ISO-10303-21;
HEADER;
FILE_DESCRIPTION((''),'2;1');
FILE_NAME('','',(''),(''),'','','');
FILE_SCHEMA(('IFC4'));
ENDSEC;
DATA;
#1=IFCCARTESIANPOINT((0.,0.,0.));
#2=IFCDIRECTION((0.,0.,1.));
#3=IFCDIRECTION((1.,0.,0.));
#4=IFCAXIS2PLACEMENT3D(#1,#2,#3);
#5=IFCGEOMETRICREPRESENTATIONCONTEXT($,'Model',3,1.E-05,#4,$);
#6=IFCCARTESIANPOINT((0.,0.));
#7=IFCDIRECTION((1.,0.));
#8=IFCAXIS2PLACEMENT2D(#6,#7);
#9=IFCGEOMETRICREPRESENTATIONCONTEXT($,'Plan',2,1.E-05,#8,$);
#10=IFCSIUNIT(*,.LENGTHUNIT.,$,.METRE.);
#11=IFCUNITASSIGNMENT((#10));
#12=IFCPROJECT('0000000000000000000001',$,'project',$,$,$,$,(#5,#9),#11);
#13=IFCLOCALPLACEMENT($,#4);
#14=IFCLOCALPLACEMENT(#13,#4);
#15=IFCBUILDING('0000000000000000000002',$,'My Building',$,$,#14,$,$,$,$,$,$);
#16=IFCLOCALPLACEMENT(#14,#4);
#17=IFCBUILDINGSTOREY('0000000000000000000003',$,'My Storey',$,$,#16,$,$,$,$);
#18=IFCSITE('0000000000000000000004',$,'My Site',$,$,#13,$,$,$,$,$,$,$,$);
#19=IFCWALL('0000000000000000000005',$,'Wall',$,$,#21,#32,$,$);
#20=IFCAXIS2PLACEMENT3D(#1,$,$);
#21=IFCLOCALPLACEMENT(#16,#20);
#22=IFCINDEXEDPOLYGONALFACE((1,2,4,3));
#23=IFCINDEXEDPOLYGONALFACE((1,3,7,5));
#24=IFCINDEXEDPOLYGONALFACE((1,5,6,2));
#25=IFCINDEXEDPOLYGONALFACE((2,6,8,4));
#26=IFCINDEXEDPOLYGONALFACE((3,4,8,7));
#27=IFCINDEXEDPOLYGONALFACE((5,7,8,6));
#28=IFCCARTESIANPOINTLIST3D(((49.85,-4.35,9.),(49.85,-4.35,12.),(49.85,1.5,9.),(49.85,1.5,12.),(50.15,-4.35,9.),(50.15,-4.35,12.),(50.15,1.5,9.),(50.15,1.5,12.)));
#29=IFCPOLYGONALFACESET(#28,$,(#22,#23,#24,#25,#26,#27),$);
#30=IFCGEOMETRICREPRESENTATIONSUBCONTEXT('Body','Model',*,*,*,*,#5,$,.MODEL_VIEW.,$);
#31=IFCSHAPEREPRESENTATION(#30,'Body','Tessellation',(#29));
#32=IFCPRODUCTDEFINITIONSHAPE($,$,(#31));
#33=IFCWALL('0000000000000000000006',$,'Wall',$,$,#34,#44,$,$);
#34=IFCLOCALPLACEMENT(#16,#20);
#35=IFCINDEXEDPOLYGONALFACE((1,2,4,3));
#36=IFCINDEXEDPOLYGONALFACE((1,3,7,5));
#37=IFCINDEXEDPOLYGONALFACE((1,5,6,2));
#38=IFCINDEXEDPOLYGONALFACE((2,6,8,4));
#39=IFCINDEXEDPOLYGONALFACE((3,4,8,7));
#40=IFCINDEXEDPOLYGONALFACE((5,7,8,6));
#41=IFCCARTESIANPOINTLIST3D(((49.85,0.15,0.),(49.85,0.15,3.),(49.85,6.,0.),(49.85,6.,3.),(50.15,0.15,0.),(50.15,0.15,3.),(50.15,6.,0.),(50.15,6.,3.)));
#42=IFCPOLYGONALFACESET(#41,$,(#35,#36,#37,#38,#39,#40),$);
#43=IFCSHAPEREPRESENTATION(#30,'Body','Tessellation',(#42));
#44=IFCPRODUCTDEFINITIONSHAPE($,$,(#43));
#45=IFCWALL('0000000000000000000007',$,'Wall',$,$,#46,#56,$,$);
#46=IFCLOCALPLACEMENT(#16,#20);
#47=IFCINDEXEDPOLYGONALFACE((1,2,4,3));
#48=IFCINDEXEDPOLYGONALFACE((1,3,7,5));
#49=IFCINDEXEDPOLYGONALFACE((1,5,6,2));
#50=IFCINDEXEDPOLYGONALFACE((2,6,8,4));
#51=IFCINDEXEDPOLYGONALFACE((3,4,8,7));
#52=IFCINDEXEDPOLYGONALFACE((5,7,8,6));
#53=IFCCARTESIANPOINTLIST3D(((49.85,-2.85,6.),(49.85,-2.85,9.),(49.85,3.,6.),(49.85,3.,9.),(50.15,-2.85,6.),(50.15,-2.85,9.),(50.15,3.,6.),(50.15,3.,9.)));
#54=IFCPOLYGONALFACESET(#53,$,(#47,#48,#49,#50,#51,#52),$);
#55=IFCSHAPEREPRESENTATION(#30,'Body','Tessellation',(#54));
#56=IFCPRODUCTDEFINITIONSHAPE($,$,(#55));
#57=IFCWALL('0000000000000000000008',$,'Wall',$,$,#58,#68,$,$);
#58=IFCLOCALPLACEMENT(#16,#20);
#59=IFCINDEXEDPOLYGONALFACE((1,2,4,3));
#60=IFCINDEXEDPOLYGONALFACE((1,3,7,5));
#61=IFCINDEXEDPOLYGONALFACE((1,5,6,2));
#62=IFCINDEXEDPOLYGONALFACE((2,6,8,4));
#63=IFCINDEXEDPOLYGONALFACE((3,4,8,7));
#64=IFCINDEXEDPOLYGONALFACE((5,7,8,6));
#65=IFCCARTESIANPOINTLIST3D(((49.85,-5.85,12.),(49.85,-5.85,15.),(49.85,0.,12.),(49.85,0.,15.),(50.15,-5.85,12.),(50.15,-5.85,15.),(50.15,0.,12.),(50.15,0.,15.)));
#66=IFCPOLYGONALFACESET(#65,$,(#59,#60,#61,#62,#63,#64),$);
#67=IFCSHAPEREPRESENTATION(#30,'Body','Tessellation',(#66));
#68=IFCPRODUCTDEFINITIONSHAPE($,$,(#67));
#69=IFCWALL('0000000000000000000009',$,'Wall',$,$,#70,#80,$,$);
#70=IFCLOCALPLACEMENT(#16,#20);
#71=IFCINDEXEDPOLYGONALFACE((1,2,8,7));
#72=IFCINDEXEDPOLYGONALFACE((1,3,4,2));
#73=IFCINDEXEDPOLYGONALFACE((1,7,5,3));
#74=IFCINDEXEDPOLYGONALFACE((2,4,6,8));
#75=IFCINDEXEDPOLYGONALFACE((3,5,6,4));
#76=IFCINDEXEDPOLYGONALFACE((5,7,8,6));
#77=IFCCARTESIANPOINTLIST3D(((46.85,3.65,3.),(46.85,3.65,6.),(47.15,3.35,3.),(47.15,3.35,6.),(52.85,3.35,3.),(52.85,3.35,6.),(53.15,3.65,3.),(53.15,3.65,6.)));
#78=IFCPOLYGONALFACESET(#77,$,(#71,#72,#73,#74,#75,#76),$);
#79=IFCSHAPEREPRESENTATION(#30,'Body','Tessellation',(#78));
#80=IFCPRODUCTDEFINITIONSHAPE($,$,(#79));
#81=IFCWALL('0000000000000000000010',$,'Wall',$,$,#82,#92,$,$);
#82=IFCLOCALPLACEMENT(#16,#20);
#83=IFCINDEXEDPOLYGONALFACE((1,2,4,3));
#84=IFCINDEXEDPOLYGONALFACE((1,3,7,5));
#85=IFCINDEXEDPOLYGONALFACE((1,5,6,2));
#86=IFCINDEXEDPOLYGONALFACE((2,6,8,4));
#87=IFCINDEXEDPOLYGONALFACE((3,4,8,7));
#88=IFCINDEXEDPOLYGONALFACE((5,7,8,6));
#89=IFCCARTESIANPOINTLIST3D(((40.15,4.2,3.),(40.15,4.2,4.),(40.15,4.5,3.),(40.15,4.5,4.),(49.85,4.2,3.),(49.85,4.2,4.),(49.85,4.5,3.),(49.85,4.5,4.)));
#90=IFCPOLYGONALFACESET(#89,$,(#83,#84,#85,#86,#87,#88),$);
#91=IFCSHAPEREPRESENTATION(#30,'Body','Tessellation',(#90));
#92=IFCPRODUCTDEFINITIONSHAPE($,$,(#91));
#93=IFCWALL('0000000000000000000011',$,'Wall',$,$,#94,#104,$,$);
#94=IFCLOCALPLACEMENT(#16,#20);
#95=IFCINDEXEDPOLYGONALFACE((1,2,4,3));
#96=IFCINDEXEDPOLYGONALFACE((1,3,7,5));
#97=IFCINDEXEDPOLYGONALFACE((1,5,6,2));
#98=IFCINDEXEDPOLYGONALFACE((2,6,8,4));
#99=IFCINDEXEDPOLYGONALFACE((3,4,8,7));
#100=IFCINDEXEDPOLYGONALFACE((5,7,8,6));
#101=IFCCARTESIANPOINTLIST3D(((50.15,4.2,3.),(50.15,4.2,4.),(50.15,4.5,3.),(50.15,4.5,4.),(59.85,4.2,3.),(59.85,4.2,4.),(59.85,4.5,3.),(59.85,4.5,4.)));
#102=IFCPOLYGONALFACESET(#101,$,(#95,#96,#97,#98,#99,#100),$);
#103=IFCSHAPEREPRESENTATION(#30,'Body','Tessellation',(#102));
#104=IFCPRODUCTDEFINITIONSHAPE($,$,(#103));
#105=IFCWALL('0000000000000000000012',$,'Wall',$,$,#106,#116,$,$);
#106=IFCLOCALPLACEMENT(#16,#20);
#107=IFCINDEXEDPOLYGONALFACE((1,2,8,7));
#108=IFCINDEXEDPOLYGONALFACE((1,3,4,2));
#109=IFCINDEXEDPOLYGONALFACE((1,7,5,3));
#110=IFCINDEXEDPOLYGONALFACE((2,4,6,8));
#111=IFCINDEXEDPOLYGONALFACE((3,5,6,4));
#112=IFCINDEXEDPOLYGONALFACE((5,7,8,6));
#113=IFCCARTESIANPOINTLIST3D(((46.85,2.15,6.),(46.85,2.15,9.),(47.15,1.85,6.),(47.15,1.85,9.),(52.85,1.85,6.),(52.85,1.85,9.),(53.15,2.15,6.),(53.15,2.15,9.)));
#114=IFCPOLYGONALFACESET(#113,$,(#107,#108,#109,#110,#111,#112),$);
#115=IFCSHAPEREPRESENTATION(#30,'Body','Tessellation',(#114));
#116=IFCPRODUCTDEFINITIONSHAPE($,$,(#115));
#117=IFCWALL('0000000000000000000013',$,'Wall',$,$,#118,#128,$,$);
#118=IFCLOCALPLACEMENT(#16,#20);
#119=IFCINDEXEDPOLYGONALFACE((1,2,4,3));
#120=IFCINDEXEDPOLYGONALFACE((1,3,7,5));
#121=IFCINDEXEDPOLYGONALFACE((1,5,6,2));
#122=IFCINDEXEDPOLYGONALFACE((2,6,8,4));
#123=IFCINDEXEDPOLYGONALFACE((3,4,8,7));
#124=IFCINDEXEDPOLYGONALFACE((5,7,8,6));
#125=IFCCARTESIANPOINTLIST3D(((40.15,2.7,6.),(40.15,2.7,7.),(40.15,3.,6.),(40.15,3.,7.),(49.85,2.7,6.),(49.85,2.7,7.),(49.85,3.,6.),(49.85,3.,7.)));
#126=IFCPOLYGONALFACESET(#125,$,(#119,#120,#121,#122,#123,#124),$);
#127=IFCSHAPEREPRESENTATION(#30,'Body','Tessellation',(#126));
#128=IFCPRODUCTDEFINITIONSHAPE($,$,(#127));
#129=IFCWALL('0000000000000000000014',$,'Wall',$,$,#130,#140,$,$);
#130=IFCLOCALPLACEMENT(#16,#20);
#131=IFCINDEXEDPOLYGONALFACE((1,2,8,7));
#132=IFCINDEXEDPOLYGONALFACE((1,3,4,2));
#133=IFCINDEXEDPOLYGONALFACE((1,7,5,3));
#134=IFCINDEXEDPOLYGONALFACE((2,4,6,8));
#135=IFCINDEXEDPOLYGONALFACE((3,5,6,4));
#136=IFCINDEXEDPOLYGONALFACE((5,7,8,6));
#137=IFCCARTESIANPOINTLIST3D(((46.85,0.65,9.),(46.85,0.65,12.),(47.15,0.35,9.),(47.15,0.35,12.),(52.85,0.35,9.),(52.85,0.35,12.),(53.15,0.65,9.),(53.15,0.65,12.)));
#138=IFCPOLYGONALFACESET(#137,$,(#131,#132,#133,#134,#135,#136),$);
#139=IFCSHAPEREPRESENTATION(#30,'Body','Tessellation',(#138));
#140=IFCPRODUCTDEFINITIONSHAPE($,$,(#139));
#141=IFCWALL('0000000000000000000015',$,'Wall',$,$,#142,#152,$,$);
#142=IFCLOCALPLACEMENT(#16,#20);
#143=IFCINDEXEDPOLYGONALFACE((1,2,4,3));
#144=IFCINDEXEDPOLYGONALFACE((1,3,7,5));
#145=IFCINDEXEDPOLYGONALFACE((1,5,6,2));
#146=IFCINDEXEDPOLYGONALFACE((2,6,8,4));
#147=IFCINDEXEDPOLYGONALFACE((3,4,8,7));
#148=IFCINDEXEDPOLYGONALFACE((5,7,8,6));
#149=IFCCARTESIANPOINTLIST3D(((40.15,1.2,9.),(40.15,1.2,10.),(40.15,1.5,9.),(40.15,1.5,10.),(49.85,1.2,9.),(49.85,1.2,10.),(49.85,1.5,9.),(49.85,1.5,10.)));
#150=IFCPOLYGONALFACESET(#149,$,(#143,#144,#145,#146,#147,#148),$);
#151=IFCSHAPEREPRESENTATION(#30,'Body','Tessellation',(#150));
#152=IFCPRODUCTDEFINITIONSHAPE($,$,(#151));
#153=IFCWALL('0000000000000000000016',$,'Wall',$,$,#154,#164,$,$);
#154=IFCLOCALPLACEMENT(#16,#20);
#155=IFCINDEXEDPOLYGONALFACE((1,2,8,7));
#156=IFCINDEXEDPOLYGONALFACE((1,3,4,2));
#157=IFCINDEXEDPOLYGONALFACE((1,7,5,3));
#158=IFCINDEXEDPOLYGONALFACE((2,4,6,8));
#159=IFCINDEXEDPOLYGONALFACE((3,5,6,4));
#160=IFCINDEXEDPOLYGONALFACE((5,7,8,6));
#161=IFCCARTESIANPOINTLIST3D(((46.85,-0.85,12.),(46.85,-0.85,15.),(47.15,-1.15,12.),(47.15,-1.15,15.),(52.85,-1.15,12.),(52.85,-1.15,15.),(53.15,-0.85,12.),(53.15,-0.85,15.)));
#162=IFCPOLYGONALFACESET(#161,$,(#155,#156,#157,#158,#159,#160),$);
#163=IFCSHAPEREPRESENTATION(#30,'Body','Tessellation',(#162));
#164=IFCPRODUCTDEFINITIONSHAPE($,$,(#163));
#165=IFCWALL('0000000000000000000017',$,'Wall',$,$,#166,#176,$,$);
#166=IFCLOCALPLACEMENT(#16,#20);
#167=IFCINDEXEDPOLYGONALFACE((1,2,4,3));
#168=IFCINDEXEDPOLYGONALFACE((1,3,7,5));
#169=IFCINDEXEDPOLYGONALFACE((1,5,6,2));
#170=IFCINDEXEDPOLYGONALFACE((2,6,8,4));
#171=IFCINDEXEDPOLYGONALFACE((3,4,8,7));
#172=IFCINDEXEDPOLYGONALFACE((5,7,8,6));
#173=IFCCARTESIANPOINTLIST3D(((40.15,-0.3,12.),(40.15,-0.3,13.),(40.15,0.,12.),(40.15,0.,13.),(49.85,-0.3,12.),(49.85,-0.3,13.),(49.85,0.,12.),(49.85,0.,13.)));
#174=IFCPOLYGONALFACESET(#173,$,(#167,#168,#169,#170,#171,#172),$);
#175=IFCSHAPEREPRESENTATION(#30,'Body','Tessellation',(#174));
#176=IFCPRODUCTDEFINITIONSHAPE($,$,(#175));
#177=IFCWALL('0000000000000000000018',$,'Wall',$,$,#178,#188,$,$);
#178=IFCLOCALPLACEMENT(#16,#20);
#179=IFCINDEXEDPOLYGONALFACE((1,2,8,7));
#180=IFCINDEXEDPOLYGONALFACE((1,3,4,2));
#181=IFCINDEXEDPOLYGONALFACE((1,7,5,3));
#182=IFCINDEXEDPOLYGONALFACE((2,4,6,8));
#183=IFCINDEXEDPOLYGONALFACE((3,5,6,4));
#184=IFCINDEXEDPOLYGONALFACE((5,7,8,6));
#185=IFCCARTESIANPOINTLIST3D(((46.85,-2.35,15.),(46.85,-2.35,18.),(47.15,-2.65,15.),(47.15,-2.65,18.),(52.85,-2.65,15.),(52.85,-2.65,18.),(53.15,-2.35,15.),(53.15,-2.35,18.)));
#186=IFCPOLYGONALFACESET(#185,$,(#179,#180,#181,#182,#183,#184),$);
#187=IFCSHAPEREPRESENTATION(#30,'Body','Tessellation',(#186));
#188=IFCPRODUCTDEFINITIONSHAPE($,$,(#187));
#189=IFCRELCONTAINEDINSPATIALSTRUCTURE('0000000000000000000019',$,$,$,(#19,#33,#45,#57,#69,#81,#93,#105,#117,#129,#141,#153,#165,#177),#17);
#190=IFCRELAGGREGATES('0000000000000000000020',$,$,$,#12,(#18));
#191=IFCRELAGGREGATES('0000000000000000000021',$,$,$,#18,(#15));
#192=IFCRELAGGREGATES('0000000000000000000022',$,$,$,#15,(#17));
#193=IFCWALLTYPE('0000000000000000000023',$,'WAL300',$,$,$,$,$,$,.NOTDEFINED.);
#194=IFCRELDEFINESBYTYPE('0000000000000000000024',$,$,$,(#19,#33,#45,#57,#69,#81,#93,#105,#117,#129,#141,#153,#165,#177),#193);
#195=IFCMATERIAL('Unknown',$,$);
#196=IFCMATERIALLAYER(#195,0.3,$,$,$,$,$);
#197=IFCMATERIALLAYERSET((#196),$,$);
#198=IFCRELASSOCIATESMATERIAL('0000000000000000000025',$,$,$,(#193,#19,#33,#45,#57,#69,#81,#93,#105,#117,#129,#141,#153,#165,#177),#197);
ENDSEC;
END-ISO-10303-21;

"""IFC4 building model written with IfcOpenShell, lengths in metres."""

from ifc_helpers import new_model, si_unit, frame, origin_with_axes, origin_2d_with_axis, place, context, subcontext, project, spatial, line, indexed_curve, outline, extrude, material, layer, layer_set, layer_usage, type_object, element, save


model = new_model("IFC4")

# Units and contexts
model_context = context("Model", 3, precision=1e-05, world=origin_with_axes())
plan_context = context("Plan", 2, precision=1e-05, world=origin_2d_with_axis())
body_context = subcontext(model_context, "Body", "Model", "MODEL_VIEW")
ifc_project = project(units=[si_unit("LENGTHUNIT", "METRE")], contexts=[model_context, plan_context])

# Site, building, storey
site_placement = place(None, origin_with_axes())
site = spatial("IfcSite", under=ifc_project, at=site_placement, Name="My Site")
building_placement = place(site_placement, origin_with_axes())
building = spatial("IfcBuilding", under=site, at=building_placement, Name="My Building")
storey_placement = place(building_placement, origin_with_axes())
storey = spatial("IfcBuildingStorey", under=building, at=storey_placement, Name="My Storey")

# Shared definitions
ifc_material = material(Name="Unknown")

# Walls
ifc_layer_1 = layer(ifc_material, 0.3)
ifc_layer_set_1 = layer_set([ifc_layer_1])
wall_type = type_object("IfcWallType", Name="WAL300", PredefinedType="NOTDEFINED", material=ifc_layer_set_1)
ifc_layer_usage_1 = layer_usage(ifc_layer_set_1, "AXIS2", "POSITIVE", -0.15)
wall_1_placement = place(storey_placement, frame((50.0, 1.5, 9.0), z_axis=(0.0, 0.0, 1.0), x_axis=(0.0, -1.0, 0.0)))
element("IfcWall", 1, at=wall_1_placement, inside=storey, type_object=wall_type, material=ifc_layer_usage_1, Name="Wall", context=body_context, shape_type="SweptSolid", body=[
    extrude(outline(indexed_curve([(0.0, -0.15), (0.0, 0.15), (5.85, 0.15), (5.85, -0.15)], segments=[line(1, 2, 3, 4, 1)])), origin_with_axes(), (0.0, 0.0, 1.0), 3.0),
])
ifc_layer_usage_2 = layer_usage(ifc_layer_set_1, "AXIS2", "POSITIVE", -0.15)
wall_2_placement = place(storey_placement, frame((50.0, 6.0, 0.0), z_axis=(0.0, 0.0, 1.0), x_axis=(0.0, -1.0, 0.0)))
element("IfcWall", 2, at=wall_2_placement, inside=storey, type_object=wall_type, material=ifc_layer_usage_2, Name="Wall", context=body_context, shape_type="SweptSolid", body=[
    extrude(outline(indexed_curve([(0.0, -0.15), (0.0, 0.15), (5.85, 0.15), (5.85, -0.15)], segments=[line(1, 2, 3, 4, 1)])), origin_with_axes(), (0.0, 0.0, 1.0), 3.0),
])
ifc_layer_usage_3 = layer_usage(ifc_layer_set_1, "AXIS2", "POSITIVE", -0.15)
wall_3_placement = place(storey_placement, frame((50.0, 3.0, 6.0), z_axis=(0.0, 0.0, 1.0), x_axis=(0.0, -1.0, 0.0)))
element("IfcWall", 3, at=wall_3_placement, inside=storey, type_object=wall_type, material=ifc_layer_usage_3, Name="Wall", context=body_context, shape_type="SweptSolid", body=[
    extrude(outline(indexed_curve([(0.0, -0.15), (0.0, 0.15), (5.85, 0.15), (5.85, -0.15)], segments=[line(1, 2, 3, 4, 1)])), origin_with_axes(), (0.0, 0.0, 1.0), 3.0),
])
ifc_layer_usage_4 = layer_usage(ifc_layer_set_1, "AXIS2", "POSITIVE", -0.15)
wall_4_placement = place(storey_placement, frame((50.0, 0.0, 12.0), z_axis=(0.0, 0.0, 1.0), x_axis=(0.0, -1.0, 0.0)))
element("IfcWall", 4, at=wall_4_placement, inside=storey, type_object=wall_type, material=ifc_layer_usage_4, Name="Wall", context=body_context, shape_type="SweptSolid", body=[
    extrude(outline(indexed_curve([(0.0, -0.15), (0.0, 0.15), (5.85, 0.15), (5.85, -0.15)], segments=[line(1, 2, 3, 4, 1)])), origin_with_axes(), (0.0, 0.0, 1.0), 3.0),
])
ifc_layer_usage_5 = layer_usage(ifc_layer_set_1, "AXIS2", "POSITIVE", -0.15)
wall_5_placement = place(storey_placement, frame((47.0, 3.5, 3.0), z_axis=(0.0, 0.0, 1.0), x_axis=(1.0, 0.0, 0.0)))
element("IfcWall", 5, at=wall_5_placement, inside=storey, type_object=wall_type, material=ifc_layer_usage_5, Name="Wall", context=body_context, shape_type="SweptSolid", body=[
    extrude(outline(indexed_curve([(0.15, -0.15), (-0.15, 0.15), (6.15, 0.15), (5.85, -0.15)], segments=[line(1, 2, 3, 4, 1)])), origin_with_axes(), (0.0, 0.0, 1.0), 3.0),
])
ifc_layer_usage_6 = layer_usage(ifc_layer_set_1, "AXIS2", "POSITIVE", -0.3)
wall_6_placement = place(storey_placement, frame((40.15, 4.5, 3.0), z_axis=(0.0, 0.0, 1.0), x_axis=(1.0, 0.0, 0.0)))
element("IfcWall", 6, at=wall_6_placement, inside=storey, type_object=wall_type, material=ifc_layer_usage_6, Name="Wall", context=body_context, shape_type="SweptSolid", body=[
    extrude(outline(indexed_curve([(0.0, -0.3), (0.0, 0.0), (9.7, 0.0), (9.7, -0.3)], segments=[line(1, 2, 3, 4, 1)])), origin_with_axes(), (0.0, 0.0, 1.0), 1.0),
])
ifc_layer_usage_7 = layer_usage(ifc_layer_set_1, "AXIS2", "POSITIVE", -0.3)
wall_7_placement = place(storey_placement, frame((50.15, 4.5, 3.0), z_axis=(0.0, 0.0, 1.0), x_axis=(1.0, 0.0, 0.0)))
element("IfcWall", 7, at=wall_7_placement, inside=storey, type_object=wall_type, material=ifc_layer_usage_7, Name="Wall", context=body_context, shape_type="SweptSolid", body=[
    extrude(outline(indexed_curve([(0.0, -0.3), (0.0, 0.0), (9.7, 0.0), (9.7, -0.3)], segments=[line(1, 2, 3, 4, 1)])), origin_with_axes(), (0.0, 0.0, 1.0), 1.0),
])
ifc_layer_usage_8 = layer_usage(ifc_layer_set_1, "AXIS2", "POSITIVE", -0.15)
wall_8_placement = place(storey_placement, frame((47.0, 2.0, 6.0), z_axis=(0.0, 0.0, 1.0), x_axis=(1.0, 0.0, 0.0)))
element("IfcWall", 8, at=wall_8_placement, inside=storey, type_object=wall_type, material=ifc_layer_usage_8, Name="Wall", context=body_context, shape_type="SweptSolid", body=[
    extrude(outline(indexed_curve([(0.15, -0.15), (-0.15, 0.15), (6.15, 0.15), (5.85, -0.15)], segments=[line(1, 2, 3, 4, 1)])), origin_with_axes(), (0.0, 0.0, 1.0), 3.0),
])
ifc_layer_usage_9 = layer_usage(ifc_layer_set_1, "AXIS2", "POSITIVE", -0.3)
wall_9_placement = place(storey_placement, frame((40.15, 3.0, 6.0), z_axis=(0.0, 0.0, 1.0), x_axis=(1.0, 0.0, 0.0)))
element("IfcWall", 9, at=wall_9_placement, inside=storey, type_object=wall_type, material=ifc_layer_usage_9, Name="Wall", context=body_context, shape_type="SweptSolid", body=[
    extrude(outline(indexed_curve([(0.0, -0.3), (0.0, 0.0), (9.7, 0.0), (9.7, -0.3)], segments=[line(1, 2, 3, 4, 1)])), origin_with_axes(), (0.0, 0.0, 1.0), 1.0),
])
ifc_layer_usage_10 = layer_usage(ifc_layer_set_1, "AXIS2", "POSITIVE", -0.15)
wall_10_placement = place(storey_placement, frame((47.0, 0.5, 9.0), z_axis=(0.0, 0.0, 1.0), x_axis=(1.0, 0.0, 0.0)))
element("IfcWall", 10, at=wall_10_placement, inside=storey, type_object=wall_type, material=ifc_layer_usage_10, Name="Wall", context=body_context, shape_type="SweptSolid", body=[
    extrude(outline(indexed_curve([(0.15, -0.15), (-0.15, 0.15), (6.15, 0.15), (5.85, -0.15)], segments=[line(1, 2, 3, 4, 1)])), origin_with_axes(), (0.0, 0.0, 1.0), 3.0),
])
ifc_layer_usage_11 = layer_usage(ifc_layer_set_1, "AXIS2", "POSITIVE", -0.3)
wall_11_placement = place(storey_placement, frame((40.15, 1.5, 9.0), z_axis=(0.0, 0.0, 1.0), x_axis=(1.0, 0.0, 0.0)))
element("IfcWall", 11, at=wall_11_placement, inside=storey, type_object=wall_type, material=ifc_layer_usage_11, Name="Wall", context=body_context, shape_type="SweptSolid", body=[
    extrude(outline(indexed_curve([(0.0, -0.3), (0.0, 0.0), (9.7, 0.0), (9.7, -0.3)], segments=[line(1, 2, 3, 4, 1)])), origin_with_axes(), (0.0, 0.0, 1.0), 1.0),
])
ifc_layer_usage_12 = layer_usage(ifc_layer_set_1, "AXIS2", "POSITIVE", -0.15)
wall_12_placement = place(storey_placement, frame((47.0, -1.0, 12.0), z_axis=(0.0, 0.0, 1.0), x_axis=(1.0, 0.0, 0.0)))
element("IfcWall", 12, at=wall_12_placement, inside=storey, type_object=wall_type, material=ifc_layer_usage_12, Name="Wall", context=body_context, shape_type="SweptSolid", body=[
    extrude(outline(indexed_curve([(0.15, -0.15), (-0.15, 0.15), (6.15, 0.15), (5.85, -0.15)], segments=[line(1, 2, 3, 4, 1)])), origin_with_axes(), (0.0, 0.0, 1.0), 3.0),
])
ifc_layer_usage_13 = layer_usage(ifc_layer_set_1, "AXIS2", "POSITIVE", -0.3)
wall_13_placement = place(storey_placement, frame((40.15, 0.0, 12.0), z_axis=(0.0, 0.0, 1.0), x_axis=(1.0, 0.0, 0.0)))
element("IfcWall", 13, at=wall_13_placement, inside=storey, type_object=wall_type, material=ifc_layer_usage_13, Name="Wall", context=body_context, shape_type="SweptSolid", body=[
    extrude(outline(indexed_curve([(0.0, -0.3), (0.0, 0.0), (9.7, 0.0), (9.7, -0.3)], segments=[line(1, 2, 3, 4, 1)])), origin_with_axes(), (0.0, 0.0, 1.0), 1.0),
])
ifc_layer_usage_14 = layer_usage(ifc_layer_set_1, "AXIS2", "POSITIVE", -0.15)
wall_14_placement = place(storey_placement, frame((47.0, -2.5, 15.0), z_axis=(0.0, 0.0, 1.0), x_axis=(1.0, 0.0, 0.0)))
element("IfcWall", 14, at=wall_14_placement, inside=storey, type_object=wall_type, material=ifc_layer_usage_14, Name="Wall", context=body_context, shape_type="SweptSolid", body=[
    extrude(outline(indexed_curve([(0.15, -0.15), (-0.15, 0.15), (6.15, 0.15), (5.85, -0.15)], segments=[line(1, 2, 3, 4, 1)])), origin_with_axes(), (0.0, 0.0, 1.0), 3.0),
])

save(model, "model.ifc")
